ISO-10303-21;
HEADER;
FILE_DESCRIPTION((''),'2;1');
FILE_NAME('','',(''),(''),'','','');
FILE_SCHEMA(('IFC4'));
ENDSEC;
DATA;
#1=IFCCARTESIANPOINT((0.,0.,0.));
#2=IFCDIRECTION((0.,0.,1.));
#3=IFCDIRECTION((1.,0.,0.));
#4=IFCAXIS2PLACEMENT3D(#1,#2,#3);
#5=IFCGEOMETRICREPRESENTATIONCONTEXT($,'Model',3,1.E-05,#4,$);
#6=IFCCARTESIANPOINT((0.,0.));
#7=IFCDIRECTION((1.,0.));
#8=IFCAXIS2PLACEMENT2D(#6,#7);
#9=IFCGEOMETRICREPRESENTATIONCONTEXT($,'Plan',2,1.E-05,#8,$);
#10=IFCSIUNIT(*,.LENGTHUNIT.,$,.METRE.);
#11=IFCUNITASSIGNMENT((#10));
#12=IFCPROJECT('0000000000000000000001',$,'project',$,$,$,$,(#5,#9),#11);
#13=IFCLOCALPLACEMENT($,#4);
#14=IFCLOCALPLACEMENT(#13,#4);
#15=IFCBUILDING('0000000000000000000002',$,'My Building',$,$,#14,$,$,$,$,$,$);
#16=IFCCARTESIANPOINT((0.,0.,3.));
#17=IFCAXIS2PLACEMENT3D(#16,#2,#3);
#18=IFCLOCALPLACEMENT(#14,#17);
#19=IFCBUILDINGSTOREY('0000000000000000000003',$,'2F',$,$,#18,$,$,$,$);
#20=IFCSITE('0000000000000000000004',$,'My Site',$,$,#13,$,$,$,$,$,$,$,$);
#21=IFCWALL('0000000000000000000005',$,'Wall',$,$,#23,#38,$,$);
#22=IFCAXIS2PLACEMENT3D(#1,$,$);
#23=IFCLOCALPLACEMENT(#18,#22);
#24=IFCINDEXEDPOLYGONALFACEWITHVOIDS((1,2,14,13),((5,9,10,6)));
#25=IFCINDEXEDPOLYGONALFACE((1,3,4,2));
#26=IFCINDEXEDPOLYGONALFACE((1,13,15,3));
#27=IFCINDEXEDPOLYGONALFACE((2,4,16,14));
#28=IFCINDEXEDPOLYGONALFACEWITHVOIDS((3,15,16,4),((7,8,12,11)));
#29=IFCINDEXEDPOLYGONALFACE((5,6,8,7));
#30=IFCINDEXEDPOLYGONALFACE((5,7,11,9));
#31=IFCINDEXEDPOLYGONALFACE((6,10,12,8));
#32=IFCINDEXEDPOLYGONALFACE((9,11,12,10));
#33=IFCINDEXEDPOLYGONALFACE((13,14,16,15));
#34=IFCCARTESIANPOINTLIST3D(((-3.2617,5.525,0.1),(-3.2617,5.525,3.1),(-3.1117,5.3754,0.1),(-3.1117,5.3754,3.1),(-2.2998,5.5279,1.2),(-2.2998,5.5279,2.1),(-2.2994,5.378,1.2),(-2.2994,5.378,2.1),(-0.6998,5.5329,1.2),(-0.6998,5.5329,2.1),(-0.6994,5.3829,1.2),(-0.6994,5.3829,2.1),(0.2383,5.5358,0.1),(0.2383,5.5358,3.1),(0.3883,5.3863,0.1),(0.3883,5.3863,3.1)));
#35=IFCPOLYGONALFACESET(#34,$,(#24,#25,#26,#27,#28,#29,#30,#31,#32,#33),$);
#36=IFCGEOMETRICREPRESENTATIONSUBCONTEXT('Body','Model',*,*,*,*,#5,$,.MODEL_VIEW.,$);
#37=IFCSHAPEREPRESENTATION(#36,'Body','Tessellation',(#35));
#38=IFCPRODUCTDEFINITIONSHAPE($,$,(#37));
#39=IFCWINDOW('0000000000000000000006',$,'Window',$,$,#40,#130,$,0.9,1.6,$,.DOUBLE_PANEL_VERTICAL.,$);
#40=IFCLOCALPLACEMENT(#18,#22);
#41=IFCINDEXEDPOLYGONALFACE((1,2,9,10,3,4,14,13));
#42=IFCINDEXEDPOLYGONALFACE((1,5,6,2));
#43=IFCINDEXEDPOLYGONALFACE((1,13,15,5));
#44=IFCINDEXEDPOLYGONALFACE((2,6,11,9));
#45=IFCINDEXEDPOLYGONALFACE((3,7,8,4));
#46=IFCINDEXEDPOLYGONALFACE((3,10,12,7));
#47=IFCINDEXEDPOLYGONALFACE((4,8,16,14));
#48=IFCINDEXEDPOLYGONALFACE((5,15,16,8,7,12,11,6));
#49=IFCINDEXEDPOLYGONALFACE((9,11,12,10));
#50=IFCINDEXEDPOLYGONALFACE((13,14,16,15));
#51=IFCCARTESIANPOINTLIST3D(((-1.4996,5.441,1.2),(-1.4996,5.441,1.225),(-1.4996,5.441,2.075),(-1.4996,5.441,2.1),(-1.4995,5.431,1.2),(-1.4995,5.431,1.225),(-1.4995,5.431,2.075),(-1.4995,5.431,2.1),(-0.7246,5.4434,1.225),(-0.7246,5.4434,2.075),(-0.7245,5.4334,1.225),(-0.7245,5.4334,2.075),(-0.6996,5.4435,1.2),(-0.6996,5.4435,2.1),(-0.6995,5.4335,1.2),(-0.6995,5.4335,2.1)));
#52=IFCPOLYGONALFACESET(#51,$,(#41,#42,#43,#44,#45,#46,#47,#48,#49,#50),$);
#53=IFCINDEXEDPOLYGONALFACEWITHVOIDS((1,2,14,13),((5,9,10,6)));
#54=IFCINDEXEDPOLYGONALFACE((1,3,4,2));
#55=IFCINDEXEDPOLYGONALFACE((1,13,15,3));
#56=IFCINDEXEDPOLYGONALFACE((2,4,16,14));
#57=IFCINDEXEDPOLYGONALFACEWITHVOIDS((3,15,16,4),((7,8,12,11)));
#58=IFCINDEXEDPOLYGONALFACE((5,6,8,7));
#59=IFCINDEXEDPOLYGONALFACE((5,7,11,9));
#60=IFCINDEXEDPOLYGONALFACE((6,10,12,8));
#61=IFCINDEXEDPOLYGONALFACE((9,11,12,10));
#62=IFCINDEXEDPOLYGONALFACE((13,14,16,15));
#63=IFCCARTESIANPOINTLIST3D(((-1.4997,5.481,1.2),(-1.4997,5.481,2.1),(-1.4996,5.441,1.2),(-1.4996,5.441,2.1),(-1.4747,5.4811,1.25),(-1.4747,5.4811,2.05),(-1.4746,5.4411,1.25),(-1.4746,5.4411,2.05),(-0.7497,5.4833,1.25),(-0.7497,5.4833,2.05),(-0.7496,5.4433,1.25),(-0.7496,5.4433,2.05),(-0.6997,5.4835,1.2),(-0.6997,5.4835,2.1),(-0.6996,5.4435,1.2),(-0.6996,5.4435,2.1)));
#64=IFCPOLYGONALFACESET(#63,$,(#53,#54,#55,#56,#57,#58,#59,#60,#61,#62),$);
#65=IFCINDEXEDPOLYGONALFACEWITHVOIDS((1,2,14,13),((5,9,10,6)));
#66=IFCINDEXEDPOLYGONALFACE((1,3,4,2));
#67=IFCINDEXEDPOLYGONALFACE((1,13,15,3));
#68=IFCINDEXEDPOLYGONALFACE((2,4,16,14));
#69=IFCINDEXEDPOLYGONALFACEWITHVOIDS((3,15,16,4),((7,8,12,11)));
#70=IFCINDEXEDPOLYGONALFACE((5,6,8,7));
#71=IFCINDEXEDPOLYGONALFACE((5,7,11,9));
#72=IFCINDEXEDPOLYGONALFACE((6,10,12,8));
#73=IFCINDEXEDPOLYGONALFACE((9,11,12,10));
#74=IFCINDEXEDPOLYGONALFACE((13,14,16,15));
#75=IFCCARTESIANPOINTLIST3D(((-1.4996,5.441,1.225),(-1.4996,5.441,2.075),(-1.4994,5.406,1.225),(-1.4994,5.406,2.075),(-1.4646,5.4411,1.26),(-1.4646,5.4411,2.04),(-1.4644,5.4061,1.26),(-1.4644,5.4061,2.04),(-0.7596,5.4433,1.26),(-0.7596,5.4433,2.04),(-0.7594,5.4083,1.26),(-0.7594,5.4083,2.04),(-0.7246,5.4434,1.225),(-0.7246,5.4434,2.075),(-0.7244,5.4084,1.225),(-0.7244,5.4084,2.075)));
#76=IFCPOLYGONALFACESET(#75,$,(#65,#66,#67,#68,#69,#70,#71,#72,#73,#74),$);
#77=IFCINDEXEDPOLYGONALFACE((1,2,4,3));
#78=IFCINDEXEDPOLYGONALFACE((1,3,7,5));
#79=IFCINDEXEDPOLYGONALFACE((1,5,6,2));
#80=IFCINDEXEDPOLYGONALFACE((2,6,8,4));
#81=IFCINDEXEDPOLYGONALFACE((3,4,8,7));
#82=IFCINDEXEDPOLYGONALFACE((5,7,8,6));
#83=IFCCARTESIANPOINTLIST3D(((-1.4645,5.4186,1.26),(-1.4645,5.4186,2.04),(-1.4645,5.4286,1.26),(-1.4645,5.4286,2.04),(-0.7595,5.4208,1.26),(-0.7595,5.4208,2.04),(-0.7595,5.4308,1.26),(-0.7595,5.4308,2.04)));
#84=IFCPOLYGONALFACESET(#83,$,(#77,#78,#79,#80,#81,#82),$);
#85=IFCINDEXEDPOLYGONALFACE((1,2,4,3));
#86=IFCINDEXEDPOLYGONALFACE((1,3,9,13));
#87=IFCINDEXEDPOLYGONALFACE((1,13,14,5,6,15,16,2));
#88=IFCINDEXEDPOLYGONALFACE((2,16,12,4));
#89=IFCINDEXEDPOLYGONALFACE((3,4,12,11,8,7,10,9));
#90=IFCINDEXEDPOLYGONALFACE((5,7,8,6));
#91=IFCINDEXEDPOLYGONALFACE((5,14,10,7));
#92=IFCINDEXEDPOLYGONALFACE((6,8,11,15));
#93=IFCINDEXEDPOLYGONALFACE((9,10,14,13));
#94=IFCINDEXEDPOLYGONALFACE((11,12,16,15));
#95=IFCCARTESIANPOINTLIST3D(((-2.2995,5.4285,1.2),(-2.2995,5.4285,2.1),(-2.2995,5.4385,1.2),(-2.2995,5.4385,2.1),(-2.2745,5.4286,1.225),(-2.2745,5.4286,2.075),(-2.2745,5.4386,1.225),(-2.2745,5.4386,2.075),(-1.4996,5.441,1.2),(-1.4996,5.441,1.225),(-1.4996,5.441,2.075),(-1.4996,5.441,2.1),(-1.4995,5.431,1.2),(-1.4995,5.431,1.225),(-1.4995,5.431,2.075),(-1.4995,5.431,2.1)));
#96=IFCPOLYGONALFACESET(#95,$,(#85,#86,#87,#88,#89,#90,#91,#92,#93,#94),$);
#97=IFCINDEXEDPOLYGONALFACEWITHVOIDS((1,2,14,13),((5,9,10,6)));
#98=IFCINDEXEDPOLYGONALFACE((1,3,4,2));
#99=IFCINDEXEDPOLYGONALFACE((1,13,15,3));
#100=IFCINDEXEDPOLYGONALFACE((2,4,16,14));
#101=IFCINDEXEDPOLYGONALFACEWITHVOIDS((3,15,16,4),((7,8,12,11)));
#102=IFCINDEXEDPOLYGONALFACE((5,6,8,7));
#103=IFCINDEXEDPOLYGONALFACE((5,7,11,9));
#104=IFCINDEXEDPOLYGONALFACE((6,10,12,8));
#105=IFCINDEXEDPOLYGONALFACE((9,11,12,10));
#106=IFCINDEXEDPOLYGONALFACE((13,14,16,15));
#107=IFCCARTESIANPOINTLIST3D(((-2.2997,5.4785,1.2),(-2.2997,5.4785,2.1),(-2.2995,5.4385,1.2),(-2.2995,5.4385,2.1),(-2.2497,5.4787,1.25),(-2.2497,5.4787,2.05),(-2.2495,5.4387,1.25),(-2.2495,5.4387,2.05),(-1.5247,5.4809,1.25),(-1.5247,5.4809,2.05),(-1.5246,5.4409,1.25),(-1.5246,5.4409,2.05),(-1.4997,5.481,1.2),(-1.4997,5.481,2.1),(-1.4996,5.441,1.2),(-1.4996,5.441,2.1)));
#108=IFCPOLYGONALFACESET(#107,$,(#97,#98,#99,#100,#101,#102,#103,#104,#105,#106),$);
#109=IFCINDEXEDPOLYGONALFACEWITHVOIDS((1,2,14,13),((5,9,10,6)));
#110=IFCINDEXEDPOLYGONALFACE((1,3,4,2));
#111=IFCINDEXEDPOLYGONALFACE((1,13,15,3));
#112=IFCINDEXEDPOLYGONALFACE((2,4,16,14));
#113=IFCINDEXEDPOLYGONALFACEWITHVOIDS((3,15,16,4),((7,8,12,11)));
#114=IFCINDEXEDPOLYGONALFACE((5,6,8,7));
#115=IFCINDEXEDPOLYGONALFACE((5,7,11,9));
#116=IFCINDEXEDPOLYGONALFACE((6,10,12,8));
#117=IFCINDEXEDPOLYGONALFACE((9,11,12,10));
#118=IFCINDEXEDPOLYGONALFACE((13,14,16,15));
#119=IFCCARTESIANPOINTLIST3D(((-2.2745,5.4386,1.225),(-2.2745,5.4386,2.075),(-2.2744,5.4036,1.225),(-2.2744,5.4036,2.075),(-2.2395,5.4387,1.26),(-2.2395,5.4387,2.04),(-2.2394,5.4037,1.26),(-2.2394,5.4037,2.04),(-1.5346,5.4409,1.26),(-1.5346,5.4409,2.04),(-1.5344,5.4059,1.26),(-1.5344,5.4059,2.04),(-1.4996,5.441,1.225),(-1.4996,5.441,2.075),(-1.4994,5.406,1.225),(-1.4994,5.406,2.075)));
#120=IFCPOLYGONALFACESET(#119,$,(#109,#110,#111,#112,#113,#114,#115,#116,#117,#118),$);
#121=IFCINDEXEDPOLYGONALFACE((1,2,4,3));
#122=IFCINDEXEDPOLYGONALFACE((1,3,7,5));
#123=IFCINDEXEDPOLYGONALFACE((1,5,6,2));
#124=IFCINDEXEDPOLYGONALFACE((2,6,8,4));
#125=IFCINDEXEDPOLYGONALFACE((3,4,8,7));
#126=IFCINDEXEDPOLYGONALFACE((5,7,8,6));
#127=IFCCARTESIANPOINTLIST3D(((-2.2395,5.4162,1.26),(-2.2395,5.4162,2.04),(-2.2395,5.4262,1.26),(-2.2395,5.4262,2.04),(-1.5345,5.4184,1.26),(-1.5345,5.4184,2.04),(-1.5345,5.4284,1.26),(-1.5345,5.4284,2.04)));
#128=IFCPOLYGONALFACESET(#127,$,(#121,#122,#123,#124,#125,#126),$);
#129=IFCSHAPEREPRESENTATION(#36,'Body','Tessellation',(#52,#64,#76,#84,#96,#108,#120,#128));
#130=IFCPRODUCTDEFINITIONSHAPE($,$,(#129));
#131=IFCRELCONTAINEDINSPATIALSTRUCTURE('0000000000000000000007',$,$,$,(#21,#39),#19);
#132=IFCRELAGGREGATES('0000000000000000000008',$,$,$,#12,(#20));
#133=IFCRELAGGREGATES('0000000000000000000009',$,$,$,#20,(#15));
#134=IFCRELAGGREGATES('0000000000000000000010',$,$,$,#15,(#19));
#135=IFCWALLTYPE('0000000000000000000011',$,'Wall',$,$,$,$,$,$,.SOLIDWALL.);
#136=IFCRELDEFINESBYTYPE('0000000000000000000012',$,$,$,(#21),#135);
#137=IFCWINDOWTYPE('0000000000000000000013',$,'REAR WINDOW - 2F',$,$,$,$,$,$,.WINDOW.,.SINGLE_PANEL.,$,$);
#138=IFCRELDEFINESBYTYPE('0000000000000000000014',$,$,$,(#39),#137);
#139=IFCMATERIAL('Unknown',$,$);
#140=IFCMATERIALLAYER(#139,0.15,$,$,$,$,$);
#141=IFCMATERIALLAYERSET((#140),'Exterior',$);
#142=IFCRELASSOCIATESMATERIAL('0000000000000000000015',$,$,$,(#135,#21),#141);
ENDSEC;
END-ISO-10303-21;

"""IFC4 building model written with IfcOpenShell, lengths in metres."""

from ifc_helpers import new_model, entity, si_unit, frame, origin_with_axes, origin_2d_with_axis, place, context, subcontext, project, spatial, line, indexed_curve, outline, extrude, shape, source, transform, mapped, material, layer, layer_set, layer_usage, type_object, type_shapes, element, fill, save


model = new_model("IFC4")

# Units and contexts
model_context = context("Model", 3, precision=1e-05, world=origin_with_axes())
plan_context = context("Plan", 2, precision=1e-05, world=origin_2d_with_axis())
body_context_1 = subcontext(model_context, "Body", "Model", "MODEL_VIEW")
body_context_2 = subcontext(plan_context, "Body", "Plan", "PLAN_VIEW")
ifc_project = project(units=[si_unit("LENGTHUNIT", "METRE")], contexts=[model_context, plan_context])

# Site, building, storey
site_placement = place(None, origin_with_axes())
site = spatial("IfcSite", under=ifc_project, at=site_placement, Name="My Site")
building_placement = place(site_placement, origin_with_axes())
building = spatial("IfcBuilding", under=site, at=building_placement, Name="My Building")
storey_placement = place(building_placement, frame((0.0, 0.0, 3.0), z_axis=(0.0, 0.0, 1.0), x_axis=(1.0, 0.0, 0.0)))
storey = spatial("IfcBuildingStorey", under=building, at=storey_placement, Name="2F")

# Shared definitions
ifc_material = material(Name="Unknown")

# Shared definitions
ifc_layer_1 = layer(ifc_material, 0.15)
ifc_layer_set_1 = layer_set([ifc_layer_1], Name="Exterior")
wall_type_1 = type_object("IfcWallType", Name="Wall", PredefinedType="SOLIDWALL", material=ifc_layer_set_1)

# Wall, opening, window
ifc_layer_usage_1 = layer_usage(ifc_layer_set_1, "AXIS2", "POSITIVE", 0.0)
wall_1_placement = place(storey_placement, frame((0.2383, 5.5358, 0.1), z_axis=(0.0, 0.0, 1.0), x_axis=(-0.999995, -0.003097, 0.0)))
wall_1 = element("IfcWall", 1, at=wall_1_placement, inside=storey, type_object=wall_type_1, material=ifc_layer_usage_1, Name="Wall", context=body_context_1, shape_type="SweptSolid", body=[
    extrude(outline(indexed_curve([(0.0, 0.0), (-0.1495, 0.15), (3.3505, 0.15), (3.5, 0.0)], segments=[line(1, 2, 3, 4, 1)])), origin_with_axes(), (0.0, 0.0, 1.0), 3.0),
])
shared_shape_1 = source(origin_with_axes(), body_context_1, "Body", "SweptSolid", [
    extrude(outline(indexed_curve([(0.0, 0.0), (1.6, 0.0), (1.6, 0.9), (0.0, 0.9)], segments=[line(1, 2, 3, 4, 1)])), frame((0.0, -0.6, 0.0), z_axis=(0.0, -1.0, 0.0), x_axis=(1.0, 0.0, 0.0)), (0.0, 0.0, -1.0), 1.2),
])
opening_1_placement = place(wall_1_placement, frame((0.9382, -0.0006, 1.1), z_axis=(0.0, 0.0, 1.0), x_axis=(1.0, 0.0, 0.0)))
opening_1 = element("IfcOpeningElement", 2, at=opening_1_placement, cuts=wall_1, PredefinedType="OPENING", context=body_context_1, shape_type="MappedRepresentation", body=[
    mapped(shared_shape_1, transform((0.0, 0.0, 0.0), x_axis=(1.0, 0.0, 0.0), y_axis=(0.0, 1.0, 0.0), z_axis=(0.0, 0.0, 1.0), scale=1.0)),
])
window_type_1 = type_object("IfcWindowType", Name="REAR WINDOW - 2F", PartitioningType="SINGLE_PANEL", PredefinedType="WINDOW")
shared_shape_2 = source(origin_with_axes(), body_context_1, "Body", "SweptSolid", [
    extrude(outline(indexed_curve([(0.8, 0.0), (0.0, 0.0), (0.0, 0.9), (0.8, 0.9), (0.8, 0.875), (0.025, 0.875), (0.025, 0.025), (0.8, 0.025)], segments=[line(1, 2, 3, 4, 5, 6, 7, 8, 1)])), frame((0.0, 0.09, 0.0), z_axis=(0.0, -1.0, 0.0), x_axis=(1.0, 0.0, 0.0)), (0.0, 0.0, -1.0), 0.01),
    extrude(outline(indexed_curve([(0.0, 0.0), (0.8, 0.0), (0.8, 0.9), (0.0, 0.9)], segments=[line(1, 2, 3, 4, 1)]), holes=[indexed_curve([(0.05, 0.05), (0.775, 0.05), (0.775, 0.85), (0.05, 0.85)], segments=[line(1, 2, 3, 4, 1)])]), frame((0.0, 0.05, 0.0), z_axis=(0.0, -1.0, 0.0), x_axis=(1.0, 0.0, 0.0)), (0.0, 0.0, -1.0), 0.04),
    extrude(outline(indexed_curve([(0.0, 0.0), (0.775, 0.0), (0.775, 0.85), (0.0, 0.85)], segments=[line(1, 2, 3, 4, 1)]), holes=[indexed_curve([(0.035, 0.035), (0.74, 0.035), (0.74, 0.815), (0.035, 0.815)], segments=[line(1, 2, 3, 4, 1)])]), frame((0.025, 0.09, 0.025), z_axis=(0.0, -1.0, 0.0), x_axis=(1.0, 0.0, 0.0)), (0.0, 0.0, -1.0), 0.035),
    extrude(outline(indexed_curve([(0.035, 0.035), (0.74, 0.035), (0.74, 0.815), (0.035, 0.815)], segments=[line(1, 2, 3, 4, 1)])), frame((0.025, 0.1025, 0.025), z_axis=(0.0, -1.0, 0.0), x_axis=(1.0, 0.0, 0.0)), (0.0, 0.0, -1.0), 0.01),
    extrude(outline(indexed_curve([(0.0, 0.9), (0.8, 0.9), (0.8, 0.0), (0.0, 0.0), (0.0, 0.025), (0.775, 0.025), (0.775, 0.875), (0.0, 0.875)], segments=[line(1, 2, 3, 4, 5, 6, 7, 8, 1)])), frame((0.8, 0.09, 0.0), z_axis=(0.0, -1.0, 0.0), x_axis=(1.0, 0.0, 0.0)), (0.0, 0.0, -1.0), 0.01),
    extrude(outline(indexed_curve([(0.0, 0.0), (0.8, 0.0), (0.8, 0.9), (0.0, 0.9)], segments=[line(1, 2, 3, 4, 1)]), holes=[indexed_curve([(0.025, 0.05), (0.75, 0.05), (0.75, 0.85), (0.025, 0.85)], segments=[line(1, 2, 3, 4, 1)])]), frame((0.8, 0.05, 0.0), z_axis=(0.0, -1.0, 0.0), x_axis=(1.0, 0.0, 0.0)), (0.0, 0.0, -1.0), 0.04),
    extrude(outline(indexed_curve([(0.0, 0.0), (0.775, 0.0), (0.775, 0.85), (0.0, 0.85)], segments=[line(1, 2, 3, 4, 1)]), holes=[indexed_curve([(0.035, 0.035), (0.74, 0.035), (0.74, 0.815), (0.035, 0.815)], segments=[line(1, 2, 3, 4, 1)])]), frame((0.8, 0.09, 0.025), z_axis=(0.0, -1.0, 0.0), x_axis=(1.0, 0.0, 0.0)), (0.0, 0.0, -1.0), 0.035),
    extrude(outline(indexed_curve([(0.035, 0.035), (0.74, 0.035), (0.74, 0.815), (0.035, 0.815)], segments=[line(1, 2, 3, 4, 1)])), frame((0.8, 0.1025, 0.025), z_axis=(0.0, -1.0, 0.0), x_axis=(1.0, 0.0, 0.0)), (0.0, 0.0, -1.0), 0.01),
])
shared_shape_3 = source(origin_with_axes(), body_context_2, "Body", "Curve2D", [
    entity("IfcIndexedPolyCurve", entity("IfcCartesianPointList2D", [[0.05, 0.05], [0.775, 0.05]])),
    entity("IfcIndexedPolyCurve", entity("IfcCartesianPointList2D", [[0.0, 0.1], [0.025, 0.1], [0.025, 0.09], [0.05, 0.09], [0.05, 0.05], [0.0, 0.05]]), [entity("IfcLineIndex", [1, 2, 3, 4, 5, 6, 1])]),
    entity("IfcIndexedPolyCurve", entity("IfcCartesianPointList2D", [[0.8, 0.1], [0.8, 0.1], [0.8, 0.09], [0.775, 0.09], [0.775, 0.05], [0.8, 0.05]])),
    entity("IfcIndexedPolyCurve", entity("IfcCartesianPointList2D", [[0.025, 0.09], [0.06, 0.09], [0.06, 0.125], [0.025, 0.125]]), [entity("IfcLineIndex", [1, 2, 3, 4, 1])]),
    entity("IfcIndexedPolyCurve", entity("IfcCartesianPointList2D", [[0.8, 0.09], [0.765, 0.09], [0.765, 0.125], [0.8, 0.125]]), [entity("IfcLineIndex", [1, 2, 3, 4, 1])]),
    entity("IfcIndexedPolyCurve", entity("IfcCartesianPointList2D", [[0.06, 0.09], [0.765, 0.09]])),
    entity("IfcIndexedPolyCurve", entity("IfcCartesianPointList2D", [[0.06, 0.125], [0.765, 0.125]])),
    entity("IfcIndexedPolyCurve", entity("IfcCartesianPointList2D", [[0.06, 0.1075], [0.765, 0.1075]])),
    entity("IfcIndexedPolyCurve", entity("IfcCartesianPointList2D", [[0.825, 0.05], [1.55, 0.05]])),
    entity("IfcIndexedPolyCurve", entity("IfcCartesianPointList2D", [[0.8, 0.1], [0.8, 0.1], [0.8, 0.09], [0.825, 0.09], [0.825, 0.05], [0.8, 0.05]])),
    entity("IfcIndexedPolyCurve", entity("IfcCartesianPointList2D", [[1.6, 0.1], [1.575, 0.1], [1.575, 0.09], [1.55, 0.09], [1.55, 0.05], [1.6, 0.05]]), [entity("IfcLineIndex", [1, 2, 3, 4, 5, 6, 1])]),
    entity("IfcIndexedPolyCurve", entity("IfcCartesianPointList2D", [[0.8, 0.09], [0.835, 0.09], [0.835, 0.125], [0.8, 0.125]]), [entity("IfcLineIndex", [1, 2, 3, 4, 1])]),
    entity("IfcIndexedPolyCurve", entity("IfcCartesianPointList2D", [[1.575, 0.09], [1.54, 0.09], [1.54, 0.125], [1.575, 0.125]]), [entity("IfcLineIndex", [1, 2, 3, 4, 1])]),
    entity("IfcIndexedPolyCurve", entity("IfcCartesianPointList2D", [[0.835, 0.09], [1.54, 0.09]])),
    entity("IfcIndexedPolyCurve", entity("IfcCartesianPointList2D", [[0.835, 0.125], [1.54, 0.125]])),
    entity("IfcIndexedPolyCurve", entity("IfcCartesianPointList2D", [[0.835, 0.1075], [1.54, 0.1075]])),
])
type_shapes(window_type_1, [shared_shape_2, shared_shape_3])
window_1_placement = place(opening_1_placement, frame((0.0, 0.0, 0.0), z_axis=(0.0, 0.0, 1.0), x_axis=(1.0, 0.0, 0.0)))
window_1 = element("IfcWindow", 3, at=window_1_placement, inside=storey, type_object=window_type_1, Name="Window", OverallHeight=0.9, OverallWidth=1.6, PartitioningType="DOUBLE_PANEL_VERTICAL", shapes=[
    shape(body_context_1, "Body", "MappedRepresentation", [mapped(shared_shape_2, transform((0.0, 0.0, 0.0), x_axis=(1.0, 0.0, 0.0), y_axis=(0.0, 1.0, 0.0), z_axis=(0.0, 0.0, 1.0), scale=1.0))]),
    shape(body_context_2, "Body", "MappedRepresentation", [mapped(shared_shape_3, transform((0.0, 0.0, 0.0), x_axis=(1.0, 0.0, 0.0), y_axis=(0.0, 1.0, 0.0), z_axis=(0.0, 0.0, 1.0), scale=1.0))]),
])
fill(opening_1, window_1)

save(model, "model.ifc")
